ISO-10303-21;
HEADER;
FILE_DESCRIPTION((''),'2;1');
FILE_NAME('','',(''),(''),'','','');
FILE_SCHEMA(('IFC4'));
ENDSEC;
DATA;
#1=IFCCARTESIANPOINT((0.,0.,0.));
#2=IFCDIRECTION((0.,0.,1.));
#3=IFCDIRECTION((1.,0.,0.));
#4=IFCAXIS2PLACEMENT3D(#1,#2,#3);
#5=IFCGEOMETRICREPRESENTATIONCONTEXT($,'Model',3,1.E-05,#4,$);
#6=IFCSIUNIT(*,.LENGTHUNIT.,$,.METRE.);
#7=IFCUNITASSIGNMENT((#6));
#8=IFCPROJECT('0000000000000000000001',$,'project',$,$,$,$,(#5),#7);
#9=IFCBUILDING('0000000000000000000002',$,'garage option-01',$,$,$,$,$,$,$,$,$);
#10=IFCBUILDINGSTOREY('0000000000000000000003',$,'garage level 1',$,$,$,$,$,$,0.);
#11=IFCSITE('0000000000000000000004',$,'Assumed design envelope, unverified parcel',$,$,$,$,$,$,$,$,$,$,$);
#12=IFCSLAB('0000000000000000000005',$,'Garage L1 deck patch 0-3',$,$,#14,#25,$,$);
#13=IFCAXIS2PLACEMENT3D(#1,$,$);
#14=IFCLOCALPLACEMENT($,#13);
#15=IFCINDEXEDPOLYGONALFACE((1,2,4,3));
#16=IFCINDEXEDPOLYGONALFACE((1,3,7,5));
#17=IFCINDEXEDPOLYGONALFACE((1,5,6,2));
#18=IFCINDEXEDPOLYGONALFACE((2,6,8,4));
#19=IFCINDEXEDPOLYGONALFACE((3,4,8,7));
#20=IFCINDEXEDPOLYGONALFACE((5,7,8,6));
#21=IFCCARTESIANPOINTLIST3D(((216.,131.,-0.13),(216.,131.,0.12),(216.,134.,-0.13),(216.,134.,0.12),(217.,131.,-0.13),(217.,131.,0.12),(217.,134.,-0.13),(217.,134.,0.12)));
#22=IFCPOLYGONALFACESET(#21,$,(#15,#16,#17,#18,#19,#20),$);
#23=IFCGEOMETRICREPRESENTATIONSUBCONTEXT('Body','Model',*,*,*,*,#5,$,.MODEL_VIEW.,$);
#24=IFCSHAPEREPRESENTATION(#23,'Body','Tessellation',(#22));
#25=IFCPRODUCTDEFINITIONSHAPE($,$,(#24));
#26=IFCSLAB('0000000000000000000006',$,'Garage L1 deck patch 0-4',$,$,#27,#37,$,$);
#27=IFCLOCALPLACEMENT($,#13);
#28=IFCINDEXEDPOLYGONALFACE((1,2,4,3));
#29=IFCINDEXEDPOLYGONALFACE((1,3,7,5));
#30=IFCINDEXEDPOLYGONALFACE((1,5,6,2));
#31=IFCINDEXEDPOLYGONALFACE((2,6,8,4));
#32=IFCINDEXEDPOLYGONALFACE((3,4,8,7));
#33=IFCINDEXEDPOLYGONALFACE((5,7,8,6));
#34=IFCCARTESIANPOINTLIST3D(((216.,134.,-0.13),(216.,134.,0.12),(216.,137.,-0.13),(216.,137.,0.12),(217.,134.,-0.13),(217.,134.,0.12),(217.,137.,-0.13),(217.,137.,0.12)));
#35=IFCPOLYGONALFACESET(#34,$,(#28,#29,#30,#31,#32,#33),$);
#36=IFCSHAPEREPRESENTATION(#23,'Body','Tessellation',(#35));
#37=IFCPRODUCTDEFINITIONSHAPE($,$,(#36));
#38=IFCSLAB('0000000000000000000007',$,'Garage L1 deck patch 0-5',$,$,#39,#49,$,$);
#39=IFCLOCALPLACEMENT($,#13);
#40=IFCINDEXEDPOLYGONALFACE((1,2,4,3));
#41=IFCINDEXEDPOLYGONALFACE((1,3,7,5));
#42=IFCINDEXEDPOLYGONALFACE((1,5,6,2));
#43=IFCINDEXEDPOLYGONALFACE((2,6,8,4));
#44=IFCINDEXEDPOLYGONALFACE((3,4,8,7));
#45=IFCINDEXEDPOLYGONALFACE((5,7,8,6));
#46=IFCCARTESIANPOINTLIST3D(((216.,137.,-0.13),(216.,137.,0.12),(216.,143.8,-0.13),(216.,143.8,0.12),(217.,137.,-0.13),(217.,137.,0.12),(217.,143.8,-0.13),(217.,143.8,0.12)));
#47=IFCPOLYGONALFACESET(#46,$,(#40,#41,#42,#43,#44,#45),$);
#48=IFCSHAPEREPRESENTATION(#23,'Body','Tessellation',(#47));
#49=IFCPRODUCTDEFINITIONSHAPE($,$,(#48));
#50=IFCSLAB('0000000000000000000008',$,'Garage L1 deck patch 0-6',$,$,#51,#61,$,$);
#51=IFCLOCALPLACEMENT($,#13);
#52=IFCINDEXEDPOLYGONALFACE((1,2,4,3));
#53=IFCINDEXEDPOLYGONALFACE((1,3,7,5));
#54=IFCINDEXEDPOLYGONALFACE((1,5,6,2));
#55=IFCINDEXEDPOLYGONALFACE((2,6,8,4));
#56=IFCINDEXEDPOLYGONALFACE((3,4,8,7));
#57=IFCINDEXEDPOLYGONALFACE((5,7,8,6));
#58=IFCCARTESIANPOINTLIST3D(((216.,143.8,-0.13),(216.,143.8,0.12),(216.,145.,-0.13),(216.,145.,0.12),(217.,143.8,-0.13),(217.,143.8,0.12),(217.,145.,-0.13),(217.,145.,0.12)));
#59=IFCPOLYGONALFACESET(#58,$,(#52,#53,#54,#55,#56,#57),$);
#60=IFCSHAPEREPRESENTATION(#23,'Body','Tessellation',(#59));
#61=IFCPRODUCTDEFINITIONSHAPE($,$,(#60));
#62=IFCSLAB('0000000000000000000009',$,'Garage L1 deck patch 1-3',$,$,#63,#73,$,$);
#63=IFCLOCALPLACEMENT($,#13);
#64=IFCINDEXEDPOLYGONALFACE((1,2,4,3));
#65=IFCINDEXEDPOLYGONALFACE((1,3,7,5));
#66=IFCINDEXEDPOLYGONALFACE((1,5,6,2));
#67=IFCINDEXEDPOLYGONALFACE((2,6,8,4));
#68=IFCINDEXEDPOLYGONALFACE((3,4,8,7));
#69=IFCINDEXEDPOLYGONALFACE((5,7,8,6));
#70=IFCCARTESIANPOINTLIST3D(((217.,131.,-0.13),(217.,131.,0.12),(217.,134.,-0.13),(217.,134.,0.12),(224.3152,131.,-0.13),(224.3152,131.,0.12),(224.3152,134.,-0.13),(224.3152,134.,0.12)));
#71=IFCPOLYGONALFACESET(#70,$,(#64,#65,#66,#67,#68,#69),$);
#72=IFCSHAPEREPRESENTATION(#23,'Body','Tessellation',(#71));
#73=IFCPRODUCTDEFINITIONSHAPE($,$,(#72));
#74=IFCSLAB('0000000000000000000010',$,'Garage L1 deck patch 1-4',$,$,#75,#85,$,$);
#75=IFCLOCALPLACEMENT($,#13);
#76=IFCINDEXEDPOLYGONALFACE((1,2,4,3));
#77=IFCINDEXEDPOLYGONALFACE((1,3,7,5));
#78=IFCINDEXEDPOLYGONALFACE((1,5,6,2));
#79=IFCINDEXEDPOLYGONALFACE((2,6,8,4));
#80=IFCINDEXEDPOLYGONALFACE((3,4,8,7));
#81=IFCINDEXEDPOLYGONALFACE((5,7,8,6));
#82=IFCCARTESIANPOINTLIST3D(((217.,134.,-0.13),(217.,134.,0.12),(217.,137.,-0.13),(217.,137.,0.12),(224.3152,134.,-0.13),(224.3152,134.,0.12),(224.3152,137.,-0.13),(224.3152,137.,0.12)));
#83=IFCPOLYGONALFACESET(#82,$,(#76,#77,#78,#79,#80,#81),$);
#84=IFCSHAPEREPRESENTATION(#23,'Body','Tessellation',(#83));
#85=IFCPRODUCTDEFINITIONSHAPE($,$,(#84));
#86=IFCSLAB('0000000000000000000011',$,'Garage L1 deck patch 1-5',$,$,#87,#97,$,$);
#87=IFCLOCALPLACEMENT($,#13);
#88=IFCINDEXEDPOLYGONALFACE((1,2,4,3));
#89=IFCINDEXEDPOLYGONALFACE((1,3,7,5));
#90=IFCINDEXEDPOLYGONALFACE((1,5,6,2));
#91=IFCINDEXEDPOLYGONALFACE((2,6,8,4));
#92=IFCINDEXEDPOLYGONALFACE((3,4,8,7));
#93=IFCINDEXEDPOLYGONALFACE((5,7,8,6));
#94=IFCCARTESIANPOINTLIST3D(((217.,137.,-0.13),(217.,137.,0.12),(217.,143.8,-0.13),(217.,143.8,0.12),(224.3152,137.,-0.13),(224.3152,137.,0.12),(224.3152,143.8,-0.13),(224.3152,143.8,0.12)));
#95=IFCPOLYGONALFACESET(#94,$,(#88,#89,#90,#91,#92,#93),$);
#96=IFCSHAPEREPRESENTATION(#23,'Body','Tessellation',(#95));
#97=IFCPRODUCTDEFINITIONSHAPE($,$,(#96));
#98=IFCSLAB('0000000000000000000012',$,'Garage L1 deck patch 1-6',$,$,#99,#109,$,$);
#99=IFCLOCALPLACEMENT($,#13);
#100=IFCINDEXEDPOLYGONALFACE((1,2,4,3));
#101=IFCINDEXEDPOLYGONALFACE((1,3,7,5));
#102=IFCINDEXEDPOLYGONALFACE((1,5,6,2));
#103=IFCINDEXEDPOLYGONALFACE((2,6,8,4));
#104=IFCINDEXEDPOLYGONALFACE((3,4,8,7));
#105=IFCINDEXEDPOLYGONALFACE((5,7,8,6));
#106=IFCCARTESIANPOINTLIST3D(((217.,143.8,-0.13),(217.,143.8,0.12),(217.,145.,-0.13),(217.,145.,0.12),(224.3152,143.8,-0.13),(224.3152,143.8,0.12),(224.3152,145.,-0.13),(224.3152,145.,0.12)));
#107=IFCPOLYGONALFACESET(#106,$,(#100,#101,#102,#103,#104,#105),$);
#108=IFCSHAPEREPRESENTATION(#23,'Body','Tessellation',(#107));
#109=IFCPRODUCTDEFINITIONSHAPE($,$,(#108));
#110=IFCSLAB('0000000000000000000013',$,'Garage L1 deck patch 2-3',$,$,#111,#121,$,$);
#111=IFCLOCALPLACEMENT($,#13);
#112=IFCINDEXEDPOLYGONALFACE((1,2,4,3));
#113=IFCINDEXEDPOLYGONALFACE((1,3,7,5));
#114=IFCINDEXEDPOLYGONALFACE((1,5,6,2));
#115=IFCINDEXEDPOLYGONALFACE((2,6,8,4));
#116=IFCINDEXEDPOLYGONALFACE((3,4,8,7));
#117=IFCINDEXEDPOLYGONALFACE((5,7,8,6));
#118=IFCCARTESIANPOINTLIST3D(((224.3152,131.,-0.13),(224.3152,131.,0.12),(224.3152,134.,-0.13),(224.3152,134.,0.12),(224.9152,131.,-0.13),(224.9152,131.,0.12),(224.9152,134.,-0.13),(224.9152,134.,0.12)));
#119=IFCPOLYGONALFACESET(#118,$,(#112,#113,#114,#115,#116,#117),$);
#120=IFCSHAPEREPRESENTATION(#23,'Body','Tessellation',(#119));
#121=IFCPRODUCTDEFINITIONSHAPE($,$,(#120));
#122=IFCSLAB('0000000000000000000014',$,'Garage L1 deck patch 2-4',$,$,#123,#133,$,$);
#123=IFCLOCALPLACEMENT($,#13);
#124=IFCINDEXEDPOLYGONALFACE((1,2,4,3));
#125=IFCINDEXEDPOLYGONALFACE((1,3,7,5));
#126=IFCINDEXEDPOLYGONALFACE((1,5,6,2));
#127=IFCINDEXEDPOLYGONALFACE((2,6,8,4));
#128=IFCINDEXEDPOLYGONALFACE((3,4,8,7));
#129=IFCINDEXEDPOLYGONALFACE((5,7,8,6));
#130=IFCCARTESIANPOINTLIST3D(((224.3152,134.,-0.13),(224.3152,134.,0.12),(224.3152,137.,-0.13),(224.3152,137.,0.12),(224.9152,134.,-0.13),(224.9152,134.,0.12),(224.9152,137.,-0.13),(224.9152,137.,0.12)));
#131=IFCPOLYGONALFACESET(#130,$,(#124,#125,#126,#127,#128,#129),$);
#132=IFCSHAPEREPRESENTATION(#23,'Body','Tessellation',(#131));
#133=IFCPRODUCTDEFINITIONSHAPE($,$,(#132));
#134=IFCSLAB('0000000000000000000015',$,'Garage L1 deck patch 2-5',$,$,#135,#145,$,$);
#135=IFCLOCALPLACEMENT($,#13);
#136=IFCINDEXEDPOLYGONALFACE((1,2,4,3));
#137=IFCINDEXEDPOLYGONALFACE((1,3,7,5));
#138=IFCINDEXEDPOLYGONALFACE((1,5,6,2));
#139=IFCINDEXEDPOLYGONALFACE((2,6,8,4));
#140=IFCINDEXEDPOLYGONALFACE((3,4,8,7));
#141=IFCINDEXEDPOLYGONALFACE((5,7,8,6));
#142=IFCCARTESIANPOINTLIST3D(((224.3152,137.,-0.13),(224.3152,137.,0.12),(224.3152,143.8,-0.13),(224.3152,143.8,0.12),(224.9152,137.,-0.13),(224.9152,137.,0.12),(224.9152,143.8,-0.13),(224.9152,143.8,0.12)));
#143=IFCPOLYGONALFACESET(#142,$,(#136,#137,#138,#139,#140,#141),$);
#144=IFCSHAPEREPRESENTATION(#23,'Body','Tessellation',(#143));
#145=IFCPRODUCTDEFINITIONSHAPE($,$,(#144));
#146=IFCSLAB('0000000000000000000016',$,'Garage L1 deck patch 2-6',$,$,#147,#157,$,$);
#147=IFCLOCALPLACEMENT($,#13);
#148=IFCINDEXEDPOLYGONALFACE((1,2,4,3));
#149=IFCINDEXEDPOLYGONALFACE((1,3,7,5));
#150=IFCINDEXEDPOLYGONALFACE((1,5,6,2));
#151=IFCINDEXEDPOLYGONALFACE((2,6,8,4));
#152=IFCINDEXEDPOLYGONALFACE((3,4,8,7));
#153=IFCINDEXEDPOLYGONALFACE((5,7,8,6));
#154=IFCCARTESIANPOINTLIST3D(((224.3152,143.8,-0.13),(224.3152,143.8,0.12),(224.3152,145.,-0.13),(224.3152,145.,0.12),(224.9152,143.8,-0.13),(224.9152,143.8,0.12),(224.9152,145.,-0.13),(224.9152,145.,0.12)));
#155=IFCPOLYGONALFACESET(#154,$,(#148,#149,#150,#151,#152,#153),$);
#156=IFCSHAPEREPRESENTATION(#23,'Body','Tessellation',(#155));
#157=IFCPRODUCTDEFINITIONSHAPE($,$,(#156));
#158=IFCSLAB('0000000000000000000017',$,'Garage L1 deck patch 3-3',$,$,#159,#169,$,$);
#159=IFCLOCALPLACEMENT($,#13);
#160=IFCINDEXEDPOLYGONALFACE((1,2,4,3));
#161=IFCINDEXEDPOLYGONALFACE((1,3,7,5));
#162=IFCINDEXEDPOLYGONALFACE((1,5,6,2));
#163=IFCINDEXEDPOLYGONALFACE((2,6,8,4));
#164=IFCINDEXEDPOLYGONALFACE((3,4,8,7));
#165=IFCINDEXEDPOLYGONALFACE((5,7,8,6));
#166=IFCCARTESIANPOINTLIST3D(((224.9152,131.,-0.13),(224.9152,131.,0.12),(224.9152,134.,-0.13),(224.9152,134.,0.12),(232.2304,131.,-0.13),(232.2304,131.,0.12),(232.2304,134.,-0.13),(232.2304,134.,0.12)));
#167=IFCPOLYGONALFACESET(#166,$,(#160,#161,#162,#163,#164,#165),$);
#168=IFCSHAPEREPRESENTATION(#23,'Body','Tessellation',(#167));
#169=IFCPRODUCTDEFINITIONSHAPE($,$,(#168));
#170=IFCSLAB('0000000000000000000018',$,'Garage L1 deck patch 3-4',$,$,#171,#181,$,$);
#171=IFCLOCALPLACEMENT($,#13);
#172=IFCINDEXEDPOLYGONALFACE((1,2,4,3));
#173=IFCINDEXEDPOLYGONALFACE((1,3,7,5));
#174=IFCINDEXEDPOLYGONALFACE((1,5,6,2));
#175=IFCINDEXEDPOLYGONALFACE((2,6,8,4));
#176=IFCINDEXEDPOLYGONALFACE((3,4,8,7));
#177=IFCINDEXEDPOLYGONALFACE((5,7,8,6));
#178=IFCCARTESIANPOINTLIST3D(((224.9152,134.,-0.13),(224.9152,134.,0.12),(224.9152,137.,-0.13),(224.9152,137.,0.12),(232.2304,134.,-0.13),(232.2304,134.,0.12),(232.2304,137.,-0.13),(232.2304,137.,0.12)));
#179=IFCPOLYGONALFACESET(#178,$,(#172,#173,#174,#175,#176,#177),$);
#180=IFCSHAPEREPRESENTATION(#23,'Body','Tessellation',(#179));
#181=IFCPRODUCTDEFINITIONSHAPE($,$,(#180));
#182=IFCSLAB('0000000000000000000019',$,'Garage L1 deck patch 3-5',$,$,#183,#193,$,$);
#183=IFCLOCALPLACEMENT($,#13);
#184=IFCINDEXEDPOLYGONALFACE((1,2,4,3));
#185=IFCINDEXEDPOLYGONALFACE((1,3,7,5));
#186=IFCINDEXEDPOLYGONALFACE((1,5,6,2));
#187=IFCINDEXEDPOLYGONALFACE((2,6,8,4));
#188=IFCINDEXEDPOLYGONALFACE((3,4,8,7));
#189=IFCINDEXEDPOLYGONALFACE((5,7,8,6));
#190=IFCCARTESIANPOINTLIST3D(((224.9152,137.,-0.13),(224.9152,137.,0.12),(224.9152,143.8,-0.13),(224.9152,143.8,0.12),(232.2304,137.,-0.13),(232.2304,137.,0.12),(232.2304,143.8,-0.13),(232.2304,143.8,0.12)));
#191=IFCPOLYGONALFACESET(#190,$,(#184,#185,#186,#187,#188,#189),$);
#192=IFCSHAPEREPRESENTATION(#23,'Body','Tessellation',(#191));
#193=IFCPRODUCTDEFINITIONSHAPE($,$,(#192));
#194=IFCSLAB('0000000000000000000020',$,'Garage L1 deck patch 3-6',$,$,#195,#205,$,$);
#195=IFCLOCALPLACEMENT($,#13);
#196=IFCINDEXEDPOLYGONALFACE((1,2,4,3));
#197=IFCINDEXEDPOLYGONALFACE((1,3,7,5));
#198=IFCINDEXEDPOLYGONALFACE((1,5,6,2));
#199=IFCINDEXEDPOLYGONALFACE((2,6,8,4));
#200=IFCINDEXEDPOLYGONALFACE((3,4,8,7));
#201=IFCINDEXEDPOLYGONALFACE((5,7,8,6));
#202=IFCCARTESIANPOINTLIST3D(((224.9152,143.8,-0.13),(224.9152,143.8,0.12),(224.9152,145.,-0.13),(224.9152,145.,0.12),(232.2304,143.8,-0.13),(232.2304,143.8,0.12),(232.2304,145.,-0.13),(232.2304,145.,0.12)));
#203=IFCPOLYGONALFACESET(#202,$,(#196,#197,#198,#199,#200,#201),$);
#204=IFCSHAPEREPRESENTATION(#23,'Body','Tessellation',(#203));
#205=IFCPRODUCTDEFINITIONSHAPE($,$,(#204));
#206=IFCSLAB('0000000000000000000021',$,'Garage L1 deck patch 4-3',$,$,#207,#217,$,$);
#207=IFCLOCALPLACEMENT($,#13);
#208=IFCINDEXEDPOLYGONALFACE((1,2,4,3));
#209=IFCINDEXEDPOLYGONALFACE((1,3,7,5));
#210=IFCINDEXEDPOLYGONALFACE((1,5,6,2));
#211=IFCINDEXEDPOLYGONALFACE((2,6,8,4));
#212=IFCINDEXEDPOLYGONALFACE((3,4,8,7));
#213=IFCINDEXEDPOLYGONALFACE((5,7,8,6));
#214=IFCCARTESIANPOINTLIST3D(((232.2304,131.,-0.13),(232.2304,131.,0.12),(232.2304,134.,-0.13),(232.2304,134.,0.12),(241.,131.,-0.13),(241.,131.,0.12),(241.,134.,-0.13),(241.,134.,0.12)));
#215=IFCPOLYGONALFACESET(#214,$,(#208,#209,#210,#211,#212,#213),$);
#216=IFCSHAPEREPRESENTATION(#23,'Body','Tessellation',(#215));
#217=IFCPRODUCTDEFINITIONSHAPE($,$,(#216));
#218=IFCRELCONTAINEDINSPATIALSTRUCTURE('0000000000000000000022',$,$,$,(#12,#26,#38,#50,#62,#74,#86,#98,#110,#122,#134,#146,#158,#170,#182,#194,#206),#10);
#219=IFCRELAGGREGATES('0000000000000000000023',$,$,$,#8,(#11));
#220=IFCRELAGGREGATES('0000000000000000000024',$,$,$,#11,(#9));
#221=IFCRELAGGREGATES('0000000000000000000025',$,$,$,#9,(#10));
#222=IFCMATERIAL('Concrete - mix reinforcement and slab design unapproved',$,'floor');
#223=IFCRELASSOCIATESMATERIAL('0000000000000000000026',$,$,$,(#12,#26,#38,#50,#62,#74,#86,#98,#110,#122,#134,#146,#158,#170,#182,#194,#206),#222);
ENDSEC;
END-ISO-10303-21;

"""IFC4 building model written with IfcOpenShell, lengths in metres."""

from ifc_helpers import new_model, si_unit, frame, origin_with_axes, place, context, subcontext, project, spatial, rectangle, extrude, material, element, save


model = new_model("IFC4")

# Units and contexts
model_context = context("Model", 3, precision=1e-05, world=origin_with_axes())
body_context = subcontext(model_context, "Body", "Model", "MODEL_VIEW")
ifc_project = project(units=[si_unit("LENGTHUNIT", "METRE")], contexts=[model_context])

# Site, building, storey
site = spatial("IfcSite", under=ifc_project, Name="Assumed design envelope, unverified parcel")
building = spatial("IfcBuilding", under=site, Name="garage option-01")
storey = spatial("IfcBuildingStorey", under=building, Name="garage level 1", Elevation=0.0)

# Slabs
ifc_material_1 = material(Name="Concrete - mix reinforcement and slab design unapproved", Category="floor")
for number, where, z_axis, x_axis, name in (
    (1, (216.5, 132.5, -0.13), (0.0, 0.0, 1.0), (1.0, 0.0, 0.0), "Garage L1 deck patch 0-3"),
    (2, (216.5, 135.5, -0.13), (0.0, 0.0, 1.0), (1.0, 0.0, 0.0), "Garage L1 deck patch 0-4"),
):
    element("IfcSlab", number, at=place(None, frame(where, z_axis=z_axis, x_axis=x_axis)), inside=storey, material=ifc_material_1, Name=name, context=body_context, shape_type="SweptSolid", body=[
        extrude(rectangle(XDim=1.0, YDim=3.0), origin_with_axes(), (0.0, 0.0, 1.0), 0.25),
    ])
slab_1_placement = place(None, frame((216.5, 140.4, -0.13), z_axis=(0.0, 0.0, 1.0), x_axis=(1.0, 0.0, 0.0)))
element("IfcSlab", 3, at=slab_1_placement, inside=storey, material=ifc_material_1, Name="Garage L1 deck patch 0-5", context=body_context, shape_type="SweptSolid", body=[
    extrude(rectangle(XDim=1.0, YDim=6.8), origin_with_axes(), (0.0, 0.0, 1.0), 0.25),
])
slab_2_placement = place(None, frame((216.5, 144.4, -0.13), z_axis=(0.0, 0.0, 1.0), x_axis=(1.0, 0.0, 0.0)))
element("IfcSlab", 4, at=slab_2_placement, inside=storey, material=ifc_material_1, Name="Garage L1 deck patch 0-6", context=body_context, shape_type="SweptSolid", body=[
    extrude(rectangle(XDim=1.0, YDim=1.2), origin_with_axes(), (0.0, 0.0, 1.0), 0.25),
])
for number, where, z_axis, x_axis, name in (
    (5, (220.6576, 132.5, -0.13), (0.0, 0.0, 1.0), (1.0, 0.0, 0.0), "Garage L1 deck patch 1-3"),
    (6, (220.6576, 135.5, -0.13), (0.0, 0.0, 1.0), (1.0, 0.0, 0.0), "Garage L1 deck patch 1-4"),
):
    element("IfcSlab", number, at=place(None, frame(where, z_axis=z_axis, x_axis=x_axis)), inside=storey, material=ifc_material_1, Name=name, context=body_context, shape_type="SweptSolid", body=[
        extrude(rectangle(XDim=7.3152, YDim=3.0), origin_with_axes(), (0.0, 0.0, 1.0), 0.25),
    ])
slab_3_placement = place(None, frame((220.6576, 140.4, -0.13), z_axis=(0.0, 0.0, 1.0), x_axis=(1.0, 0.0, 0.0)))
element("IfcSlab", 7, at=slab_3_placement, inside=storey, material=ifc_material_1, Name="Garage L1 deck patch 1-5", context=body_context, shape_type="SweptSolid", body=[
    extrude(rectangle(XDim=7.3152, YDim=6.8), origin_with_axes(), (0.0, 0.0, 1.0), 0.25),
])
slab_4_placement = place(None, frame((220.6576, 144.4, -0.13), z_axis=(0.0, 0.0, 1.0), x_axis=(1.0, 0.0, 0.0)))
element("IfcSlab", 8, at=slab_4_placement, inside=storey, material=ifc_material_1, Name="Garage L1 deck patch 1-6", context=body_context, shape_type="SweptSolid", body=[
    extrude(rectangle(XDim=7.3152, YDim=1.2), origin_with_axes(), (0.0, 0.0, 1.0), 0.25),
])
for number, where, z_axis, x_axis, name in (
    (9, (224.6152, 132.5, -0.13), (0.0, 0.0, 1.0), (1.0, 0.0, 0.0), "Garage L1 deck patch 2-3"),
    (10, (224.6152, 135.5, -0.13), (0.0, 0.0, 1.0), (1.0, 0.0, 0.0), "Garage L1 deck patch 2-4"),
):
    element("IfcSlab", number, at=place(None, frame(where, z_axis=z_axis, x_axis=x_axis)), inside=storey, material=ifc_material_1, Name=name, context=body_context, shape_type="SweptSolid", body=[
        extrude(rectangle(XDim=0.6, YDim=3.0), origin_with_axes(), (0.0, 0.0, 1.0), 0.25),
    ])
slab_5_placement = place(None, frame((224.6152, 140.4, -0.13), z_axis=(0.0, 0.0, 1.0), x_axis=(1.0, 0.0, 0.0)))
element("IfcSlab", 11, at=slab_5_placement, inside=storey, material=ifc_material_1, Name="Garage L1 deck patch 2-5", context=body_context, shape_type="SweptSolid", body=[
    extrude(rectangle(XDim=0.6, YDim=6.8), origin_with_axes(), (0.0, 0.0, 1.0), 0.25),
])
slab_6_placement = place(None, frame((224.6152, 144.4, -0.13), z_axis=(0.0, 0.0, 1.0), x_axis=(1.0, 0.0, 0.0)))
element("IfcSlab", 12, at=slab_6_placement, inside=storey, material=ifc_material_1, Name="Garage L1 deck patch 2-6", context=body_context, shape_type="SweptSolid", body=[
    extrude(rectangle(XDim=0.6, YDim=1.2), origin_with_axes(), (0.0, 0.0, 1.0), 0.25),
])
for number, where, z_axis, x_axis, name in (
    (13, (228.5728, 132.5, -0.13), (0.0, 0.0, 1.0), (1.0, 0.0, 0.0), "Garage L1 deck patch 3-3"),
    (14, (228.5728, 135.5, -0.13), (0.0, 0.0, 1.0), (1.0, 0.0, 0.0), "Garage L1 deck patch 3-4"),
):
    element("IfcSlab", number, at=place(None, frame(where, z_axis=z_axis, x_axis=x_axis)), inside=storey, material=ifc_material_1, Name=name, context=body_context, shape_type="SweptSolid", body=[
        extrude(rectangle(XDim=7.3152, YDim=3.0), origin_with_axes(), (0.0, 0.0, 1.0), 0.25),
    ])
slab_7_placement = place(None, frame((228.5728, 140.4, -0.13), z_axis=(0.0, 0.0, 1.0), x_axis=(1.0, 0.0, 0.0)))
element("IfcSlab", 15, at=slab_7_placement, inside=storey, material=ifc_material_1, Name="Garage L1 deck patch 3-5", context=body_context, shape_type="SweptSolid", body=[
    extrude(rectangle(XDim=7.3152, YDim=6.8), origin_with_axes(), (0.0, 0.0, 1.0), 0.25),
])
slab_8_placement = place(None, frame((228.5728, 144.4, -0.13), z_axis=(0.0, 0.0, 1.0), x_axis=(1.0, 0.0, 0.0)))
element("IfcSlab", 16, at=slab_8_placement, inside=storey, material=ifc_material_1, Name="Garage L1 deck patch 3-6", context=body_context, shape_type="SweptSolid", body=[
    extrude(rectangle(XDim=7.3152, YDim=1.2), origin_with_axes(), (0.0, 0.0, 1.0), 0.25),
])
for number, where, z_axis, x_axis, name in (
    (17, (236.6152, 132.5, -0.13), (0.0, 0.0, 1.0), (1.0, 0.0, 0.0), "Garage L1 deck patch 4-3"),
):
    element("IfcSlab", number, at=place(None, frame(where, z_axis=z_axis, x_axis=x_axis)), inside=storey, material=ifc_material_1, Name=name, context=body_context, shape_type="SweptSolid", body=[
        extrude(rectangle(XDim=8.7696, YDim=3.0), origin_with_axes(), (0.0, 0.0, 1.0), 0.25),
    ])

save(model, "model.ifc")
